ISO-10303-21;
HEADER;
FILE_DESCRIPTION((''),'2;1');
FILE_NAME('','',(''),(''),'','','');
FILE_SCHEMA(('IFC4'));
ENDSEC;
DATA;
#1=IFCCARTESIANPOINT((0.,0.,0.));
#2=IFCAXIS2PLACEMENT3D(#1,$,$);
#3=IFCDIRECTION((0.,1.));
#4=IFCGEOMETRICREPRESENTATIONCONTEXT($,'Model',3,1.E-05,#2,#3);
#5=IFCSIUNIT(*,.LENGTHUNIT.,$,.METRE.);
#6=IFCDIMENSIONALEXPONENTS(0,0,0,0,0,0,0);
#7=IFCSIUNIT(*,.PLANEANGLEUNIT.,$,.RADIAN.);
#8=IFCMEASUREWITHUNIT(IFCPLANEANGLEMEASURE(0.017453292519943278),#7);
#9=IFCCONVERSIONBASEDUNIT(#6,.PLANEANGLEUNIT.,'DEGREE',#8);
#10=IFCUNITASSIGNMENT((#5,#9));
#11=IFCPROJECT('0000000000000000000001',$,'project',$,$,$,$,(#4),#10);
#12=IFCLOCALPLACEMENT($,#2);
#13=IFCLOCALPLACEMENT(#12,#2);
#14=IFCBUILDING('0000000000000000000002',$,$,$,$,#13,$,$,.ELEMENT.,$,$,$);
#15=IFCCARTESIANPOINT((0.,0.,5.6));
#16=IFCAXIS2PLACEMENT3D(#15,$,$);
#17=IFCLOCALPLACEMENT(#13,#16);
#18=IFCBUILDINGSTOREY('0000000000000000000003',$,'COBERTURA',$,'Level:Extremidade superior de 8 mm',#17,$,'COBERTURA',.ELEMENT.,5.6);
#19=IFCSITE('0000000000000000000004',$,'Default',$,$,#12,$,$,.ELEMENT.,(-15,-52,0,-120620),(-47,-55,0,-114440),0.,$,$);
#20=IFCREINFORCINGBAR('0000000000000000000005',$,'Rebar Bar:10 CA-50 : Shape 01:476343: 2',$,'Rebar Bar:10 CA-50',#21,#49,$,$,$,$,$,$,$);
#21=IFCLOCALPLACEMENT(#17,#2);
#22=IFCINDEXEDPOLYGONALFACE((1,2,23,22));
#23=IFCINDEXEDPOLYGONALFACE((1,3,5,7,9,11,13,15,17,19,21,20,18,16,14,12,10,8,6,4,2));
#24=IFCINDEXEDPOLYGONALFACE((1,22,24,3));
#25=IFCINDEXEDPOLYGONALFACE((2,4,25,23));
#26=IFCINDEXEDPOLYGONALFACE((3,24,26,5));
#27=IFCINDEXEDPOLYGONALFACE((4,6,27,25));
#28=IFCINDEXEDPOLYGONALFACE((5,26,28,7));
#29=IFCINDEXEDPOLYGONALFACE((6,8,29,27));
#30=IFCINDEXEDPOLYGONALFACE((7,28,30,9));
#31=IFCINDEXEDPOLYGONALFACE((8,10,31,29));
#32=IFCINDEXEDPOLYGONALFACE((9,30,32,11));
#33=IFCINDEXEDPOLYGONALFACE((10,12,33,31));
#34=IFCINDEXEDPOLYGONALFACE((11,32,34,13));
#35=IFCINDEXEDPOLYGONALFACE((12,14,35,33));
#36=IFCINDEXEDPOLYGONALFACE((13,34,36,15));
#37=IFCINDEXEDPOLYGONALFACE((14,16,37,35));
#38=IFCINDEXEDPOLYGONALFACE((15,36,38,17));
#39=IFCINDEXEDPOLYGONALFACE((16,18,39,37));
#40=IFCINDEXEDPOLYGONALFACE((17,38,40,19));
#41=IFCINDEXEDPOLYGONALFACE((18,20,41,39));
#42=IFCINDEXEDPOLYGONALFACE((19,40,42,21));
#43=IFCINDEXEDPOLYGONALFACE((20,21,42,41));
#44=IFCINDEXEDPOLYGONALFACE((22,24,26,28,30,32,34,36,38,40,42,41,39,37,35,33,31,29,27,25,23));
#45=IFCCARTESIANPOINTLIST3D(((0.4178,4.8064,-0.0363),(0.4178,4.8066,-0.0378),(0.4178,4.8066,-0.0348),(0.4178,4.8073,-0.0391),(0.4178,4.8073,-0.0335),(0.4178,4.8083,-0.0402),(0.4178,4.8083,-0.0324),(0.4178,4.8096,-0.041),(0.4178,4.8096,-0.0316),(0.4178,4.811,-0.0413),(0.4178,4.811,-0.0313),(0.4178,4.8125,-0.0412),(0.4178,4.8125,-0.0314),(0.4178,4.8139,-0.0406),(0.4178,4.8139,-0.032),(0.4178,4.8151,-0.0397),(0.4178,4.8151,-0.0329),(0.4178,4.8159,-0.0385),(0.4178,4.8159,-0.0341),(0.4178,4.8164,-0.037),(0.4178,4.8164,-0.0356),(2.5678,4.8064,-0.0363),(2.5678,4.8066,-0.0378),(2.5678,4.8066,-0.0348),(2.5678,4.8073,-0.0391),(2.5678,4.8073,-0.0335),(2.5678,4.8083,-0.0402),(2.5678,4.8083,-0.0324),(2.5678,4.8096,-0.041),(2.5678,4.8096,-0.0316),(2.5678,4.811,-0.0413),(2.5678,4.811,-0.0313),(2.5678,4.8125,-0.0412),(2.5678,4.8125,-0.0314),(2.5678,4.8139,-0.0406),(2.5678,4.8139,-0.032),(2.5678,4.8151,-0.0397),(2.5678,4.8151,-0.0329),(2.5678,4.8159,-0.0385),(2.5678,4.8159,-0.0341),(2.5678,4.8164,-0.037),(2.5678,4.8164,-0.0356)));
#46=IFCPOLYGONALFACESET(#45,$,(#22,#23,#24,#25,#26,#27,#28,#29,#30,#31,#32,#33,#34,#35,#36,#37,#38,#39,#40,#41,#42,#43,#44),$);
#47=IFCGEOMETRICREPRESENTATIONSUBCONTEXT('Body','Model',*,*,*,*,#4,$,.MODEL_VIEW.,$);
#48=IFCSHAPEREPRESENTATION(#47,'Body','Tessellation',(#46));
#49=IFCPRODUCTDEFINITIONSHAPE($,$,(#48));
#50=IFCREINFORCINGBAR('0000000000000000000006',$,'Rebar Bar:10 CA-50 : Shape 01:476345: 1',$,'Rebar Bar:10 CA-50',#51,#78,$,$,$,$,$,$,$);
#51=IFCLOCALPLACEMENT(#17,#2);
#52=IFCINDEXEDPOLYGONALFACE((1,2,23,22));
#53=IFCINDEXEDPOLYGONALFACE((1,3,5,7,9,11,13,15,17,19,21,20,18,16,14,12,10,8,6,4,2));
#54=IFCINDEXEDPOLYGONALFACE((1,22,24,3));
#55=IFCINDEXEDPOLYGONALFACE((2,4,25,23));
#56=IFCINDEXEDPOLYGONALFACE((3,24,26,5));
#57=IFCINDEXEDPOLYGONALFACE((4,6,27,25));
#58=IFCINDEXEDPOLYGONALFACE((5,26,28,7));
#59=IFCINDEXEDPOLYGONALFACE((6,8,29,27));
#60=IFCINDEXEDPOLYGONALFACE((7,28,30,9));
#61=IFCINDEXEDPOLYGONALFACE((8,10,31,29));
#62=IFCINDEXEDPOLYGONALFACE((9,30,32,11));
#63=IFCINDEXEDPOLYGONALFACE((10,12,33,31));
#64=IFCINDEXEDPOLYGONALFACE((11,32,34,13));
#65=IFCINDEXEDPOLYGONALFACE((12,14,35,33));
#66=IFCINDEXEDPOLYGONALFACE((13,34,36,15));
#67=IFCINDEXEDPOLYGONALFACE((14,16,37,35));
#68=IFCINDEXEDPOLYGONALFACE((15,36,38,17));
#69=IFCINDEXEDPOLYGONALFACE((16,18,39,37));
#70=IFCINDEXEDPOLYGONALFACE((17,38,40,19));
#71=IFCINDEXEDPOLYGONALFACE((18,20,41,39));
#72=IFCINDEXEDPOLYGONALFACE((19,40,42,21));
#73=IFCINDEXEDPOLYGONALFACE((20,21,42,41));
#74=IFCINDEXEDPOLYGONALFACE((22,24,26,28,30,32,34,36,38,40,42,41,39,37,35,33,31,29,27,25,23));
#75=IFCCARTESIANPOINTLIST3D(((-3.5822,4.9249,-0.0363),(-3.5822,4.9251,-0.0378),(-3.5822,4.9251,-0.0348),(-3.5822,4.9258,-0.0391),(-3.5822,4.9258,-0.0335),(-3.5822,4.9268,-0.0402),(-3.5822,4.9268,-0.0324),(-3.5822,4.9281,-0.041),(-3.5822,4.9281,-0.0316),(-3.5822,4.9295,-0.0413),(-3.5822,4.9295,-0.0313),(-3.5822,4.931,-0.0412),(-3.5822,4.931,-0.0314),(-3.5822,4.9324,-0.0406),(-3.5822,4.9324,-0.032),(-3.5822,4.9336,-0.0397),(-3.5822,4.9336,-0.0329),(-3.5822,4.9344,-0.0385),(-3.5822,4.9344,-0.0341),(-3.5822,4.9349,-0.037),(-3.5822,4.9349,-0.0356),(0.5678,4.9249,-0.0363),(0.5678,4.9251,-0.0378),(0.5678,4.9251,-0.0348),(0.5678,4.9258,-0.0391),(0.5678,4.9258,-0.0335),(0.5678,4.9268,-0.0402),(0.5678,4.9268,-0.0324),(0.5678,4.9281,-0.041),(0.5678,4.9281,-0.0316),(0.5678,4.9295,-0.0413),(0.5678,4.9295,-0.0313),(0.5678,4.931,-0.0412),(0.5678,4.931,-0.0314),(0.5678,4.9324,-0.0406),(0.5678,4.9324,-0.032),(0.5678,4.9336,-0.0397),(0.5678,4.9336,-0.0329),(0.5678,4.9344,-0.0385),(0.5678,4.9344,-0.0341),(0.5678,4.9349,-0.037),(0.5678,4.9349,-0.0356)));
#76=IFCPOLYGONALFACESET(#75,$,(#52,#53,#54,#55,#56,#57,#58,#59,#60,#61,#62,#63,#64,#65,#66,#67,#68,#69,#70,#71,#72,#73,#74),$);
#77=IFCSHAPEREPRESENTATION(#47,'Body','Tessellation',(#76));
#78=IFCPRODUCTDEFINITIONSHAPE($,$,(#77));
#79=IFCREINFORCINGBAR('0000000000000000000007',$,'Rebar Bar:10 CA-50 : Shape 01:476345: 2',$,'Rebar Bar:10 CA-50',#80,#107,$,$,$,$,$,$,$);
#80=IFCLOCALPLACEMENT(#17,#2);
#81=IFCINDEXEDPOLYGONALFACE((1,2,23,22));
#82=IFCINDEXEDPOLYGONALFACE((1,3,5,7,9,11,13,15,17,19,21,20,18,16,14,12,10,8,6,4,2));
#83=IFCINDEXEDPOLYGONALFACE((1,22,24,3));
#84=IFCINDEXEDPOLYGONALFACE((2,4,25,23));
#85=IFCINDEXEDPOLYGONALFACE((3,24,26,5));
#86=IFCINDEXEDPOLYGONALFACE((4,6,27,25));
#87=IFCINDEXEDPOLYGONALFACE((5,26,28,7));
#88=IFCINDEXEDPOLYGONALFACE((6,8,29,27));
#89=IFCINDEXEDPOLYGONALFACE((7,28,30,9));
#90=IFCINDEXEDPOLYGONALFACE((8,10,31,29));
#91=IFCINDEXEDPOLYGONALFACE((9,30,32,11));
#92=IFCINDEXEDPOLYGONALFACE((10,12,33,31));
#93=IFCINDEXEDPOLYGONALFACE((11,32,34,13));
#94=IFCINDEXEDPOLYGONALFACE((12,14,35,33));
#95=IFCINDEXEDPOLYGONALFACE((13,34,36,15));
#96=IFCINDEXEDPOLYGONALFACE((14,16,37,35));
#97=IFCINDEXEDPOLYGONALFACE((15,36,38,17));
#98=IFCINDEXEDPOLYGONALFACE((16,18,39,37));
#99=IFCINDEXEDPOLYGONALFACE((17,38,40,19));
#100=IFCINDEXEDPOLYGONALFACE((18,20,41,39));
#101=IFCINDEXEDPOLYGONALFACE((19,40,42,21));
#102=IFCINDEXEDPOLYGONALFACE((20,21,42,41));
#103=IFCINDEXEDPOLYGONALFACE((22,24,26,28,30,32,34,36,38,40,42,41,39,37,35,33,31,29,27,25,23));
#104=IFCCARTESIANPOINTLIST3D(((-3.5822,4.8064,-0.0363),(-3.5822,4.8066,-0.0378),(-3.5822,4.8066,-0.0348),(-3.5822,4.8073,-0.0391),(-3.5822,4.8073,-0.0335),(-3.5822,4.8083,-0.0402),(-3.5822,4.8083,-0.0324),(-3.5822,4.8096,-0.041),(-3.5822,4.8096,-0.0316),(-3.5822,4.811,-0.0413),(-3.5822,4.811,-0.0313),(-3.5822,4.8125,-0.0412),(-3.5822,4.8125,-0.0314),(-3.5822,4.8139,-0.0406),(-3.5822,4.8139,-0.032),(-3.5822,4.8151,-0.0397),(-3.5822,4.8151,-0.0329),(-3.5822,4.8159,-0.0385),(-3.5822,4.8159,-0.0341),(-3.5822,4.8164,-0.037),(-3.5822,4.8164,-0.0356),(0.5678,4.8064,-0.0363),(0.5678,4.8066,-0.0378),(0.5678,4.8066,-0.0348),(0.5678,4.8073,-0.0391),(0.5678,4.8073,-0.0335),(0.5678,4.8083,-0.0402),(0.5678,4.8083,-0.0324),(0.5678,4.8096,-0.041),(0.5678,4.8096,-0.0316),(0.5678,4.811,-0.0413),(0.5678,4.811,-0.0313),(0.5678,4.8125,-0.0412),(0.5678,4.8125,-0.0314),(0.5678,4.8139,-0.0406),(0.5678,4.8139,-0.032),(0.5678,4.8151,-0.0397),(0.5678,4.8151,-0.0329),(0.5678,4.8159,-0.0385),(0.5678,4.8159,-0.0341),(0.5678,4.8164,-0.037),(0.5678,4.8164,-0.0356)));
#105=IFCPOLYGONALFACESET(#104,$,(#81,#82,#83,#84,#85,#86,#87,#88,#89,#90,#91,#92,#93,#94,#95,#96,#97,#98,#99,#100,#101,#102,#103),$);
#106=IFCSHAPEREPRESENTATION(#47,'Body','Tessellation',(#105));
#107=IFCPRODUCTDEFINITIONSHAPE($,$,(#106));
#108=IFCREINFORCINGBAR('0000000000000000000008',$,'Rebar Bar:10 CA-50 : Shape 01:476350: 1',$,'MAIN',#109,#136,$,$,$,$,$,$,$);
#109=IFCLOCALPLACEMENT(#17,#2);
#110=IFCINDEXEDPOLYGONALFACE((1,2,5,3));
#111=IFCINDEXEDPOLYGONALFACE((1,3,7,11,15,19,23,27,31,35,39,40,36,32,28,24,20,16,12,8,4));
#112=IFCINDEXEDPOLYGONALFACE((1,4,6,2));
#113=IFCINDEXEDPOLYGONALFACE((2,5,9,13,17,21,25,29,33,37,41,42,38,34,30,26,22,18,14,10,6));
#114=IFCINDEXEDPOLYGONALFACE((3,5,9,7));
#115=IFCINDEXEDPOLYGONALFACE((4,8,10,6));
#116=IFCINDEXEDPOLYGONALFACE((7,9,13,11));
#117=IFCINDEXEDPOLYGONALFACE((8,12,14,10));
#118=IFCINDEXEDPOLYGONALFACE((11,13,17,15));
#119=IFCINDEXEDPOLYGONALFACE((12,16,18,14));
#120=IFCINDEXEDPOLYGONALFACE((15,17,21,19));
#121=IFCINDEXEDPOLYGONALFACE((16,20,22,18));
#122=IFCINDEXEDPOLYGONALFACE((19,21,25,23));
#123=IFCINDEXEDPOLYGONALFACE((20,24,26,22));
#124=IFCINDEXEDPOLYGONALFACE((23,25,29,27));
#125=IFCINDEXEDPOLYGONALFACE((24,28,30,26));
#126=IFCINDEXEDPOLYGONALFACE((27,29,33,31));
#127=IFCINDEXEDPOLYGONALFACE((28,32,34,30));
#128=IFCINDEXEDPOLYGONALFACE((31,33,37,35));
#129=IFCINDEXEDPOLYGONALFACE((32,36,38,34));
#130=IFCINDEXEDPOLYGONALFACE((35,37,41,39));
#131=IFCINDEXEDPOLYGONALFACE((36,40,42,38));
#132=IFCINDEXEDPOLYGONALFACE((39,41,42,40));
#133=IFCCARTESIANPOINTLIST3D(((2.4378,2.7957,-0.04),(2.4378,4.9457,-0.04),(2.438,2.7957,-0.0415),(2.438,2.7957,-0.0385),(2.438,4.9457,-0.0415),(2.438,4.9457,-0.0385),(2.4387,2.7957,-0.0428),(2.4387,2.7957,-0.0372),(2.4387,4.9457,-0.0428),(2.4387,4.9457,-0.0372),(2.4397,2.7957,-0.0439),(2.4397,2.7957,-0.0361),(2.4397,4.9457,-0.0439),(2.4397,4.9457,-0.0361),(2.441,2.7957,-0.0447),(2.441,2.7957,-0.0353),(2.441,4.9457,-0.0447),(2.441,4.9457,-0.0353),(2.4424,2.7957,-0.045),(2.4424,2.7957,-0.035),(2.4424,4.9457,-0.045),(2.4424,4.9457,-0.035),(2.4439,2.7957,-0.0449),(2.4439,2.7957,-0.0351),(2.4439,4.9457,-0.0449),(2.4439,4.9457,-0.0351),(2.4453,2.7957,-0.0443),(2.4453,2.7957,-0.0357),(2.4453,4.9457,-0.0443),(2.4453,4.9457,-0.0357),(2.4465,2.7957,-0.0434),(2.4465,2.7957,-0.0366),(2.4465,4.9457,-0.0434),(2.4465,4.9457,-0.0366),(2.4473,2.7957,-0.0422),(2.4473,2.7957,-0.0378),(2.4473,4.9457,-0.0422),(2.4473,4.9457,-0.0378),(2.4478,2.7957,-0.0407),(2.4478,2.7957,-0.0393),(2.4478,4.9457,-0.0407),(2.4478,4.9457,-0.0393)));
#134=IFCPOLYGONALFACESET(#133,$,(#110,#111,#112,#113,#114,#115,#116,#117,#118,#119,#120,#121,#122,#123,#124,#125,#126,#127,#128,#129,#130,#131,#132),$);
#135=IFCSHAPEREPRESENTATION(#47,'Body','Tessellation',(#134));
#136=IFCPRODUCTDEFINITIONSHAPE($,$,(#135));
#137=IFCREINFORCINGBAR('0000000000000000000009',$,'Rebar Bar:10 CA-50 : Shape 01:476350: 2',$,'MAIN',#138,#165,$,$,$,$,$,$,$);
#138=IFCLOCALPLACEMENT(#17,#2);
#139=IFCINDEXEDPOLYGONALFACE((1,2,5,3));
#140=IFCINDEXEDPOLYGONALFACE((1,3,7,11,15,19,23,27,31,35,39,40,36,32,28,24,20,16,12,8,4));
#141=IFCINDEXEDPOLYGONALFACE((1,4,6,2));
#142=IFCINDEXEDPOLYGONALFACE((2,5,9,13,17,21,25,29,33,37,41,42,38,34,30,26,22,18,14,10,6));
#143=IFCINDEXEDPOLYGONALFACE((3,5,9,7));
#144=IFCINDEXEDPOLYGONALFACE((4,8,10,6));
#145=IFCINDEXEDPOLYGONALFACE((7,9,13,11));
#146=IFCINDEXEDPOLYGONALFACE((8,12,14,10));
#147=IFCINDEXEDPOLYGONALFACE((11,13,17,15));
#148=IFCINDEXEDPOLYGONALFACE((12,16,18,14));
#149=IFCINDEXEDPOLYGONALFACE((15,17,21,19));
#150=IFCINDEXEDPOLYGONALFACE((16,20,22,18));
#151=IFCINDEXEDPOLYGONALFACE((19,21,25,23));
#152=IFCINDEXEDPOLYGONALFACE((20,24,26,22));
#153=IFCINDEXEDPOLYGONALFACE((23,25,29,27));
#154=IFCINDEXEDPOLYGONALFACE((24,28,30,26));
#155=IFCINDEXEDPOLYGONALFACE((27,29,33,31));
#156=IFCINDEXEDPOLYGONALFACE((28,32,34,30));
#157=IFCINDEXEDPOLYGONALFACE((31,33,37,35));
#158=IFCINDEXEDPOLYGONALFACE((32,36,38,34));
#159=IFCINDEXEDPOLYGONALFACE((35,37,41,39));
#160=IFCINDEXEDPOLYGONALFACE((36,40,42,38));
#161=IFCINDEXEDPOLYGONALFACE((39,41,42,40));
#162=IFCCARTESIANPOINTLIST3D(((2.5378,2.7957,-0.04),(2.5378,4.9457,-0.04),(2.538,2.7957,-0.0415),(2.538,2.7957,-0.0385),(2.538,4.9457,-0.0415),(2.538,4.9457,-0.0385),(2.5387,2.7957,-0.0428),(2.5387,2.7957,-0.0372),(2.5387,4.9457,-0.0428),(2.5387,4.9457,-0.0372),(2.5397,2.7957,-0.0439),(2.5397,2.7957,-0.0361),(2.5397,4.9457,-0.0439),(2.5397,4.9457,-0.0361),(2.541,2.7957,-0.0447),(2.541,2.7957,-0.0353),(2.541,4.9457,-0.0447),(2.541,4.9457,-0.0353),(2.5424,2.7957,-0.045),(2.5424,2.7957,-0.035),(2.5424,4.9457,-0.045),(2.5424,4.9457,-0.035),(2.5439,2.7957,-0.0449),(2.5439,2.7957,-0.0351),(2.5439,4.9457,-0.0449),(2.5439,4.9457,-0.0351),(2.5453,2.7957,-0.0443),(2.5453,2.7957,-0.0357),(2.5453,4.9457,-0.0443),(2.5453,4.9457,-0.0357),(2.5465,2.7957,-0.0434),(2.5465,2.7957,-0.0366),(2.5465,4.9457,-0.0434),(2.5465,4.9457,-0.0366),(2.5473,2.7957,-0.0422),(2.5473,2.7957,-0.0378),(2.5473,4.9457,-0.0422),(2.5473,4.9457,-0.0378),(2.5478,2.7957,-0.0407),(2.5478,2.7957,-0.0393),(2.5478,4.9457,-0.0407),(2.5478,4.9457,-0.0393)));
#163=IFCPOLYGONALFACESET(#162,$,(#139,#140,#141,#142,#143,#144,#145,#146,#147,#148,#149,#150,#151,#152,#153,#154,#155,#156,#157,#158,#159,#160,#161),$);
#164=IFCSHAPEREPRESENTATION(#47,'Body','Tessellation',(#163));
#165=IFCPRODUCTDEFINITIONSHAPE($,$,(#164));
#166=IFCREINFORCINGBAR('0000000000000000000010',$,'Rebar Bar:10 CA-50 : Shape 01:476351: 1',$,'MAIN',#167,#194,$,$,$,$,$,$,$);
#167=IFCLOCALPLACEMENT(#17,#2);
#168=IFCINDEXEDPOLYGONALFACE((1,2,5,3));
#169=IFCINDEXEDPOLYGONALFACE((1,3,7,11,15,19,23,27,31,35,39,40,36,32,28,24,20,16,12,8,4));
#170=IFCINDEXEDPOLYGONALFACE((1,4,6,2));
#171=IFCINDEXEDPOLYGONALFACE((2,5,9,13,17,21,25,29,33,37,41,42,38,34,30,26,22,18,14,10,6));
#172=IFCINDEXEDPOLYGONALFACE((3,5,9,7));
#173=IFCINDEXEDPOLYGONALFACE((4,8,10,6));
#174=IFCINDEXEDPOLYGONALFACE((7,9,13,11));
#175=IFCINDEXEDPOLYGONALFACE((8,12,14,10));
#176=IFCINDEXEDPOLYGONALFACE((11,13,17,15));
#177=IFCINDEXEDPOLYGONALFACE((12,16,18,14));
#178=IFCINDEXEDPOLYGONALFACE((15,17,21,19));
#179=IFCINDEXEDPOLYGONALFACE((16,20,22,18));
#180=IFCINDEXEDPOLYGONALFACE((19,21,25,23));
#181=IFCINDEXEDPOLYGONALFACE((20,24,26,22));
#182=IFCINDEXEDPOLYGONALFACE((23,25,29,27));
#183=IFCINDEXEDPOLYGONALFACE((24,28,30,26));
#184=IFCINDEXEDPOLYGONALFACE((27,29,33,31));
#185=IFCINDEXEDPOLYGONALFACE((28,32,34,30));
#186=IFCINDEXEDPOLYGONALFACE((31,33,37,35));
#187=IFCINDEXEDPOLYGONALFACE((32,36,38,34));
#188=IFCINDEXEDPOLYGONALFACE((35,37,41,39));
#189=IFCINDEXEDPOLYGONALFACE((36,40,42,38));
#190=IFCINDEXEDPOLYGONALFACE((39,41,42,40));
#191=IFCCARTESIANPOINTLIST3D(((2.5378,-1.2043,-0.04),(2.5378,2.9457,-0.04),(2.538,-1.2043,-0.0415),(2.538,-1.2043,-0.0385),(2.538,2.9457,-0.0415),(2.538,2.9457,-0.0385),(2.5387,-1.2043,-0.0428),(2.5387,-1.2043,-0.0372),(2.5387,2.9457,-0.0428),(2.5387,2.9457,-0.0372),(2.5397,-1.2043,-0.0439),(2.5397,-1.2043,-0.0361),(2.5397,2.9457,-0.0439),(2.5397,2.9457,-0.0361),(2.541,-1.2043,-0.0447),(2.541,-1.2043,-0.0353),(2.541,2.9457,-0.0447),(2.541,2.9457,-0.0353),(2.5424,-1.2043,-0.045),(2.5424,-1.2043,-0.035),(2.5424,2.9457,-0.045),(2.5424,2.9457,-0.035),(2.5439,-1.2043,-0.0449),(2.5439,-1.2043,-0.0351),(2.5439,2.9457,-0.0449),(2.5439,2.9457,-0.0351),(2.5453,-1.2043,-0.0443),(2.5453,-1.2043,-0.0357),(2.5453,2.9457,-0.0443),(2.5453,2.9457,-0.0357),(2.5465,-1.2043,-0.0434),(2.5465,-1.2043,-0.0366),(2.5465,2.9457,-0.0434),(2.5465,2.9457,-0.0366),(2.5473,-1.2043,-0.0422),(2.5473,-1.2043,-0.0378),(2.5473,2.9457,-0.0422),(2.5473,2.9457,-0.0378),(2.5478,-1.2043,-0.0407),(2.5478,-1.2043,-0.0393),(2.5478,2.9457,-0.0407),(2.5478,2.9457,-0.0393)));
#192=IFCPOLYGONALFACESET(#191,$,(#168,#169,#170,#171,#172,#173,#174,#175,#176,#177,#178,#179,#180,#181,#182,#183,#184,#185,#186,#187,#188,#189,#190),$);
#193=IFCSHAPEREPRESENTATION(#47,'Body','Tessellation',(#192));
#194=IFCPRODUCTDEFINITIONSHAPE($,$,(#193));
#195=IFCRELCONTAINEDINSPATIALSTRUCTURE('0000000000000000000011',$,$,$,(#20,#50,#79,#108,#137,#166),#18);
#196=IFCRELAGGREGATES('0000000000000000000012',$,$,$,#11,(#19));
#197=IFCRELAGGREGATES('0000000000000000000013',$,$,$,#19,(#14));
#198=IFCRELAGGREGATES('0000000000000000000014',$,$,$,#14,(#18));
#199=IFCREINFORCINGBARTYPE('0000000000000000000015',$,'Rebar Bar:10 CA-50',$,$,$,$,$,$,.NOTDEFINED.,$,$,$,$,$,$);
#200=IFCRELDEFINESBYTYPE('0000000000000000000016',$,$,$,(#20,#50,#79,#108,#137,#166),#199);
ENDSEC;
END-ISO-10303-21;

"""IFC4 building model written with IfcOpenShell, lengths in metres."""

from ifc_helpers import new_model, entity, si_unit, converted_unit, direction, frame, origin, place, context, subcontext, project, spatial, type_object, element, save


model = new_model("IFC4")

# Units and contexts
model_context = context("Model", 3, precision=1e-05, world=origin(), true_north=direction((0.0, 1.0)))
body_context = subcontext(model_context, "Body", "Model", "MODEL_VIEW")
ifc_project = project(units=[si_unit("LENGTHUNIT", "METRE"), converted_unit("PLANEANGLEUNIT", "DEGREE", entity("IfcPlaneAngleMeasure", 0.017453292519943278), si_unit("PLANEANGLEUNIT", "RADIAN"), dimensions=[0, 0, 0, 0, 0, 0, 0])], contexts=[model_context])

# Site, building, storey
site_placement = place(None, origin())
site = spatial("IfcSite", under=ifc_project, at=site_placement, Name="Default", CompositionType="ELEMENT", RefLatitude=(-15, -52, 0, -120620), RefLongitude=(-47, -55, 0, -114440), RefElevation=0.0)
building_placement = place(site_placement, origin())
building = spatial("IfcBuilding", under=site, at=building_placement, CompositionType="ELEMENT")
storey_placement = place(building_placement, frame((0.0, 0.0, 5.6)))
storey = spatial("IfcBuildingStorey", under=building, at=storey_placement, Name="COBERTURA", ObjectType="Level:Extremidade superior de 8 mm", LongName="COBERTURA", CompositionType="ELEMENT", Elevation=5.6)

# Reinforcing bars
reinforcing_bar_type = type_object("IfcReinforcingBarType", Name="Rebar Bar:10 CA-50", PredefinedType="NOTDEFINED")
reinforcing_bar_1_placement = place(storey_placement, origin())
element("IfcReinforcingBar", 1, at=reinforcing_bar_1_placement, inside=storey, type_object=reinforcing_bar_type, Name="Rebar Bar:10 CA-50 : Shape 01:476343: 2", ObjectType="Rebar Bar:10 CA-50", context=body_context, shape_type="AdvancedSweptSolid", body=[
    entity("IfcSweptDiskSolid", entity("IfcIndexedPolyCurve", entity("IfcCartesianPointList3D", [[2.5678, 4.8114, -0.0363], [0.4178, 4.8114, -0.0363]]), None, False), 0.005, None, 0.0, 1.0),
])
reinforcing_bar_2_placement = place(storey_placement, origin())
element("IfcReinforcingBar", 2, at=reinforcing_bar_2_placement, inside=storey, type_object=reinforcing_bar_type, Name="Rebar Bar:10 CA-50 : Shape 01:476345: 1", ObjectType="Rebar Bar:10 CA-50", context=body_context, shape_type="AdvancedSweptSolid", body=[
    entity("IfcSweptDiskSolid", entity("IfcIndexedPolyCurve", entity("IfcCartesianPointList3D", [[0.5678, 4.9299, -0.0363], [-3.5822, 4.9299, -0.0363]]), None, False), 0.005, None, 0.0, 1.0),
])
reinforcing_bar_3_placement = place(storey_placement, origin())
element("IfcReinforcingBar", 3, at=reinforcing_bar_3_placement, inside=storey, type_object=reinforcing_bar_type, Name="Rebar Bar:10 CA-50 : Shape 01:476345: 2", ObjectType="Rebar Bar:10 CA-50", context=body_context, shape_type="AdvancedSweptSolid", body=[
    entity("IfcSweptDiskSolid", entity("IfcIndexedPolyCurve", entity("IfcCartesianPointList3D", [[0.5678, 4.8114, -0.0363], [-3.5822, 4.8114, -0.0363]]), None, False), 0.005, None, 0.0, 1.0),
])
reinforcing_bar_4_placement = place(storey_placement, origin())
element("IfcReinforcingBar", 4, at=reinforcing_bar_4_placement, inside=storey, type_object=reinforcing_bar_type, Name="Rebar Bar:10 CA-50 : Shape 01:476350: 1", ObjectType="MAIN", context=body_context, shape_type="AdvancedSweptSolid", body=[
    entity("IfcSweptDiskSolid", entity("IfcIndexedPolyCurve", entity("IfcCartesianPointList3D", [[2.4428, 4.9457, -0.04], [2.4428, 2.7957, -0.04]]), None, False), 0.005, None, 0.0, 1.0),
])
reinforcing_bar_5_placement = place(storey_placement, origin())
element("IfcReinforcingBar", 5, at=reinforcing_bar_5_placement, inside=storey, type_object=reinforcing_bar_type, Name="Rebar Bar:10 CA-50 : Shape 01:476350: 2", ObjectType="MAIN", context=body_context, shape_type="AdvancedSweptSolid", body=[
    entity("IfcSweptDiskSolid", entity("IfcIndexedPolyCurve", entity("IfcCartesianPointList3D", [[2.5428, 4.9457, -0.04], [2.5428, 2.7957, -0.04]]), None, False), 0.005, None, 0.0, 1.0),
])
reinforcing_bar_6_placement = place(storey_placement, origin())
element("IfcReinforcingBar", 6, at=reinforcing_bar_6_placement, inside=storey, type_object=reinforcing_bar_type, Name="Rebar Bar:10 CA-50 : Shape 01:476351: 1", ObjectType="MAIN", context=body_context, shape_type="AdvancedSweptSolid", body=[
    entity("IfcSweptDiskSolid", entity("IfcIndexedPolyCurve", entity("IfcCartesianPointList3D", [[2.5428, 2.9457, -0.04], [2.5428, -1.2043, -0.04]]), None, False), 0.005, None, 0.0, 1.0),
])

save(model, "model.ifc")
